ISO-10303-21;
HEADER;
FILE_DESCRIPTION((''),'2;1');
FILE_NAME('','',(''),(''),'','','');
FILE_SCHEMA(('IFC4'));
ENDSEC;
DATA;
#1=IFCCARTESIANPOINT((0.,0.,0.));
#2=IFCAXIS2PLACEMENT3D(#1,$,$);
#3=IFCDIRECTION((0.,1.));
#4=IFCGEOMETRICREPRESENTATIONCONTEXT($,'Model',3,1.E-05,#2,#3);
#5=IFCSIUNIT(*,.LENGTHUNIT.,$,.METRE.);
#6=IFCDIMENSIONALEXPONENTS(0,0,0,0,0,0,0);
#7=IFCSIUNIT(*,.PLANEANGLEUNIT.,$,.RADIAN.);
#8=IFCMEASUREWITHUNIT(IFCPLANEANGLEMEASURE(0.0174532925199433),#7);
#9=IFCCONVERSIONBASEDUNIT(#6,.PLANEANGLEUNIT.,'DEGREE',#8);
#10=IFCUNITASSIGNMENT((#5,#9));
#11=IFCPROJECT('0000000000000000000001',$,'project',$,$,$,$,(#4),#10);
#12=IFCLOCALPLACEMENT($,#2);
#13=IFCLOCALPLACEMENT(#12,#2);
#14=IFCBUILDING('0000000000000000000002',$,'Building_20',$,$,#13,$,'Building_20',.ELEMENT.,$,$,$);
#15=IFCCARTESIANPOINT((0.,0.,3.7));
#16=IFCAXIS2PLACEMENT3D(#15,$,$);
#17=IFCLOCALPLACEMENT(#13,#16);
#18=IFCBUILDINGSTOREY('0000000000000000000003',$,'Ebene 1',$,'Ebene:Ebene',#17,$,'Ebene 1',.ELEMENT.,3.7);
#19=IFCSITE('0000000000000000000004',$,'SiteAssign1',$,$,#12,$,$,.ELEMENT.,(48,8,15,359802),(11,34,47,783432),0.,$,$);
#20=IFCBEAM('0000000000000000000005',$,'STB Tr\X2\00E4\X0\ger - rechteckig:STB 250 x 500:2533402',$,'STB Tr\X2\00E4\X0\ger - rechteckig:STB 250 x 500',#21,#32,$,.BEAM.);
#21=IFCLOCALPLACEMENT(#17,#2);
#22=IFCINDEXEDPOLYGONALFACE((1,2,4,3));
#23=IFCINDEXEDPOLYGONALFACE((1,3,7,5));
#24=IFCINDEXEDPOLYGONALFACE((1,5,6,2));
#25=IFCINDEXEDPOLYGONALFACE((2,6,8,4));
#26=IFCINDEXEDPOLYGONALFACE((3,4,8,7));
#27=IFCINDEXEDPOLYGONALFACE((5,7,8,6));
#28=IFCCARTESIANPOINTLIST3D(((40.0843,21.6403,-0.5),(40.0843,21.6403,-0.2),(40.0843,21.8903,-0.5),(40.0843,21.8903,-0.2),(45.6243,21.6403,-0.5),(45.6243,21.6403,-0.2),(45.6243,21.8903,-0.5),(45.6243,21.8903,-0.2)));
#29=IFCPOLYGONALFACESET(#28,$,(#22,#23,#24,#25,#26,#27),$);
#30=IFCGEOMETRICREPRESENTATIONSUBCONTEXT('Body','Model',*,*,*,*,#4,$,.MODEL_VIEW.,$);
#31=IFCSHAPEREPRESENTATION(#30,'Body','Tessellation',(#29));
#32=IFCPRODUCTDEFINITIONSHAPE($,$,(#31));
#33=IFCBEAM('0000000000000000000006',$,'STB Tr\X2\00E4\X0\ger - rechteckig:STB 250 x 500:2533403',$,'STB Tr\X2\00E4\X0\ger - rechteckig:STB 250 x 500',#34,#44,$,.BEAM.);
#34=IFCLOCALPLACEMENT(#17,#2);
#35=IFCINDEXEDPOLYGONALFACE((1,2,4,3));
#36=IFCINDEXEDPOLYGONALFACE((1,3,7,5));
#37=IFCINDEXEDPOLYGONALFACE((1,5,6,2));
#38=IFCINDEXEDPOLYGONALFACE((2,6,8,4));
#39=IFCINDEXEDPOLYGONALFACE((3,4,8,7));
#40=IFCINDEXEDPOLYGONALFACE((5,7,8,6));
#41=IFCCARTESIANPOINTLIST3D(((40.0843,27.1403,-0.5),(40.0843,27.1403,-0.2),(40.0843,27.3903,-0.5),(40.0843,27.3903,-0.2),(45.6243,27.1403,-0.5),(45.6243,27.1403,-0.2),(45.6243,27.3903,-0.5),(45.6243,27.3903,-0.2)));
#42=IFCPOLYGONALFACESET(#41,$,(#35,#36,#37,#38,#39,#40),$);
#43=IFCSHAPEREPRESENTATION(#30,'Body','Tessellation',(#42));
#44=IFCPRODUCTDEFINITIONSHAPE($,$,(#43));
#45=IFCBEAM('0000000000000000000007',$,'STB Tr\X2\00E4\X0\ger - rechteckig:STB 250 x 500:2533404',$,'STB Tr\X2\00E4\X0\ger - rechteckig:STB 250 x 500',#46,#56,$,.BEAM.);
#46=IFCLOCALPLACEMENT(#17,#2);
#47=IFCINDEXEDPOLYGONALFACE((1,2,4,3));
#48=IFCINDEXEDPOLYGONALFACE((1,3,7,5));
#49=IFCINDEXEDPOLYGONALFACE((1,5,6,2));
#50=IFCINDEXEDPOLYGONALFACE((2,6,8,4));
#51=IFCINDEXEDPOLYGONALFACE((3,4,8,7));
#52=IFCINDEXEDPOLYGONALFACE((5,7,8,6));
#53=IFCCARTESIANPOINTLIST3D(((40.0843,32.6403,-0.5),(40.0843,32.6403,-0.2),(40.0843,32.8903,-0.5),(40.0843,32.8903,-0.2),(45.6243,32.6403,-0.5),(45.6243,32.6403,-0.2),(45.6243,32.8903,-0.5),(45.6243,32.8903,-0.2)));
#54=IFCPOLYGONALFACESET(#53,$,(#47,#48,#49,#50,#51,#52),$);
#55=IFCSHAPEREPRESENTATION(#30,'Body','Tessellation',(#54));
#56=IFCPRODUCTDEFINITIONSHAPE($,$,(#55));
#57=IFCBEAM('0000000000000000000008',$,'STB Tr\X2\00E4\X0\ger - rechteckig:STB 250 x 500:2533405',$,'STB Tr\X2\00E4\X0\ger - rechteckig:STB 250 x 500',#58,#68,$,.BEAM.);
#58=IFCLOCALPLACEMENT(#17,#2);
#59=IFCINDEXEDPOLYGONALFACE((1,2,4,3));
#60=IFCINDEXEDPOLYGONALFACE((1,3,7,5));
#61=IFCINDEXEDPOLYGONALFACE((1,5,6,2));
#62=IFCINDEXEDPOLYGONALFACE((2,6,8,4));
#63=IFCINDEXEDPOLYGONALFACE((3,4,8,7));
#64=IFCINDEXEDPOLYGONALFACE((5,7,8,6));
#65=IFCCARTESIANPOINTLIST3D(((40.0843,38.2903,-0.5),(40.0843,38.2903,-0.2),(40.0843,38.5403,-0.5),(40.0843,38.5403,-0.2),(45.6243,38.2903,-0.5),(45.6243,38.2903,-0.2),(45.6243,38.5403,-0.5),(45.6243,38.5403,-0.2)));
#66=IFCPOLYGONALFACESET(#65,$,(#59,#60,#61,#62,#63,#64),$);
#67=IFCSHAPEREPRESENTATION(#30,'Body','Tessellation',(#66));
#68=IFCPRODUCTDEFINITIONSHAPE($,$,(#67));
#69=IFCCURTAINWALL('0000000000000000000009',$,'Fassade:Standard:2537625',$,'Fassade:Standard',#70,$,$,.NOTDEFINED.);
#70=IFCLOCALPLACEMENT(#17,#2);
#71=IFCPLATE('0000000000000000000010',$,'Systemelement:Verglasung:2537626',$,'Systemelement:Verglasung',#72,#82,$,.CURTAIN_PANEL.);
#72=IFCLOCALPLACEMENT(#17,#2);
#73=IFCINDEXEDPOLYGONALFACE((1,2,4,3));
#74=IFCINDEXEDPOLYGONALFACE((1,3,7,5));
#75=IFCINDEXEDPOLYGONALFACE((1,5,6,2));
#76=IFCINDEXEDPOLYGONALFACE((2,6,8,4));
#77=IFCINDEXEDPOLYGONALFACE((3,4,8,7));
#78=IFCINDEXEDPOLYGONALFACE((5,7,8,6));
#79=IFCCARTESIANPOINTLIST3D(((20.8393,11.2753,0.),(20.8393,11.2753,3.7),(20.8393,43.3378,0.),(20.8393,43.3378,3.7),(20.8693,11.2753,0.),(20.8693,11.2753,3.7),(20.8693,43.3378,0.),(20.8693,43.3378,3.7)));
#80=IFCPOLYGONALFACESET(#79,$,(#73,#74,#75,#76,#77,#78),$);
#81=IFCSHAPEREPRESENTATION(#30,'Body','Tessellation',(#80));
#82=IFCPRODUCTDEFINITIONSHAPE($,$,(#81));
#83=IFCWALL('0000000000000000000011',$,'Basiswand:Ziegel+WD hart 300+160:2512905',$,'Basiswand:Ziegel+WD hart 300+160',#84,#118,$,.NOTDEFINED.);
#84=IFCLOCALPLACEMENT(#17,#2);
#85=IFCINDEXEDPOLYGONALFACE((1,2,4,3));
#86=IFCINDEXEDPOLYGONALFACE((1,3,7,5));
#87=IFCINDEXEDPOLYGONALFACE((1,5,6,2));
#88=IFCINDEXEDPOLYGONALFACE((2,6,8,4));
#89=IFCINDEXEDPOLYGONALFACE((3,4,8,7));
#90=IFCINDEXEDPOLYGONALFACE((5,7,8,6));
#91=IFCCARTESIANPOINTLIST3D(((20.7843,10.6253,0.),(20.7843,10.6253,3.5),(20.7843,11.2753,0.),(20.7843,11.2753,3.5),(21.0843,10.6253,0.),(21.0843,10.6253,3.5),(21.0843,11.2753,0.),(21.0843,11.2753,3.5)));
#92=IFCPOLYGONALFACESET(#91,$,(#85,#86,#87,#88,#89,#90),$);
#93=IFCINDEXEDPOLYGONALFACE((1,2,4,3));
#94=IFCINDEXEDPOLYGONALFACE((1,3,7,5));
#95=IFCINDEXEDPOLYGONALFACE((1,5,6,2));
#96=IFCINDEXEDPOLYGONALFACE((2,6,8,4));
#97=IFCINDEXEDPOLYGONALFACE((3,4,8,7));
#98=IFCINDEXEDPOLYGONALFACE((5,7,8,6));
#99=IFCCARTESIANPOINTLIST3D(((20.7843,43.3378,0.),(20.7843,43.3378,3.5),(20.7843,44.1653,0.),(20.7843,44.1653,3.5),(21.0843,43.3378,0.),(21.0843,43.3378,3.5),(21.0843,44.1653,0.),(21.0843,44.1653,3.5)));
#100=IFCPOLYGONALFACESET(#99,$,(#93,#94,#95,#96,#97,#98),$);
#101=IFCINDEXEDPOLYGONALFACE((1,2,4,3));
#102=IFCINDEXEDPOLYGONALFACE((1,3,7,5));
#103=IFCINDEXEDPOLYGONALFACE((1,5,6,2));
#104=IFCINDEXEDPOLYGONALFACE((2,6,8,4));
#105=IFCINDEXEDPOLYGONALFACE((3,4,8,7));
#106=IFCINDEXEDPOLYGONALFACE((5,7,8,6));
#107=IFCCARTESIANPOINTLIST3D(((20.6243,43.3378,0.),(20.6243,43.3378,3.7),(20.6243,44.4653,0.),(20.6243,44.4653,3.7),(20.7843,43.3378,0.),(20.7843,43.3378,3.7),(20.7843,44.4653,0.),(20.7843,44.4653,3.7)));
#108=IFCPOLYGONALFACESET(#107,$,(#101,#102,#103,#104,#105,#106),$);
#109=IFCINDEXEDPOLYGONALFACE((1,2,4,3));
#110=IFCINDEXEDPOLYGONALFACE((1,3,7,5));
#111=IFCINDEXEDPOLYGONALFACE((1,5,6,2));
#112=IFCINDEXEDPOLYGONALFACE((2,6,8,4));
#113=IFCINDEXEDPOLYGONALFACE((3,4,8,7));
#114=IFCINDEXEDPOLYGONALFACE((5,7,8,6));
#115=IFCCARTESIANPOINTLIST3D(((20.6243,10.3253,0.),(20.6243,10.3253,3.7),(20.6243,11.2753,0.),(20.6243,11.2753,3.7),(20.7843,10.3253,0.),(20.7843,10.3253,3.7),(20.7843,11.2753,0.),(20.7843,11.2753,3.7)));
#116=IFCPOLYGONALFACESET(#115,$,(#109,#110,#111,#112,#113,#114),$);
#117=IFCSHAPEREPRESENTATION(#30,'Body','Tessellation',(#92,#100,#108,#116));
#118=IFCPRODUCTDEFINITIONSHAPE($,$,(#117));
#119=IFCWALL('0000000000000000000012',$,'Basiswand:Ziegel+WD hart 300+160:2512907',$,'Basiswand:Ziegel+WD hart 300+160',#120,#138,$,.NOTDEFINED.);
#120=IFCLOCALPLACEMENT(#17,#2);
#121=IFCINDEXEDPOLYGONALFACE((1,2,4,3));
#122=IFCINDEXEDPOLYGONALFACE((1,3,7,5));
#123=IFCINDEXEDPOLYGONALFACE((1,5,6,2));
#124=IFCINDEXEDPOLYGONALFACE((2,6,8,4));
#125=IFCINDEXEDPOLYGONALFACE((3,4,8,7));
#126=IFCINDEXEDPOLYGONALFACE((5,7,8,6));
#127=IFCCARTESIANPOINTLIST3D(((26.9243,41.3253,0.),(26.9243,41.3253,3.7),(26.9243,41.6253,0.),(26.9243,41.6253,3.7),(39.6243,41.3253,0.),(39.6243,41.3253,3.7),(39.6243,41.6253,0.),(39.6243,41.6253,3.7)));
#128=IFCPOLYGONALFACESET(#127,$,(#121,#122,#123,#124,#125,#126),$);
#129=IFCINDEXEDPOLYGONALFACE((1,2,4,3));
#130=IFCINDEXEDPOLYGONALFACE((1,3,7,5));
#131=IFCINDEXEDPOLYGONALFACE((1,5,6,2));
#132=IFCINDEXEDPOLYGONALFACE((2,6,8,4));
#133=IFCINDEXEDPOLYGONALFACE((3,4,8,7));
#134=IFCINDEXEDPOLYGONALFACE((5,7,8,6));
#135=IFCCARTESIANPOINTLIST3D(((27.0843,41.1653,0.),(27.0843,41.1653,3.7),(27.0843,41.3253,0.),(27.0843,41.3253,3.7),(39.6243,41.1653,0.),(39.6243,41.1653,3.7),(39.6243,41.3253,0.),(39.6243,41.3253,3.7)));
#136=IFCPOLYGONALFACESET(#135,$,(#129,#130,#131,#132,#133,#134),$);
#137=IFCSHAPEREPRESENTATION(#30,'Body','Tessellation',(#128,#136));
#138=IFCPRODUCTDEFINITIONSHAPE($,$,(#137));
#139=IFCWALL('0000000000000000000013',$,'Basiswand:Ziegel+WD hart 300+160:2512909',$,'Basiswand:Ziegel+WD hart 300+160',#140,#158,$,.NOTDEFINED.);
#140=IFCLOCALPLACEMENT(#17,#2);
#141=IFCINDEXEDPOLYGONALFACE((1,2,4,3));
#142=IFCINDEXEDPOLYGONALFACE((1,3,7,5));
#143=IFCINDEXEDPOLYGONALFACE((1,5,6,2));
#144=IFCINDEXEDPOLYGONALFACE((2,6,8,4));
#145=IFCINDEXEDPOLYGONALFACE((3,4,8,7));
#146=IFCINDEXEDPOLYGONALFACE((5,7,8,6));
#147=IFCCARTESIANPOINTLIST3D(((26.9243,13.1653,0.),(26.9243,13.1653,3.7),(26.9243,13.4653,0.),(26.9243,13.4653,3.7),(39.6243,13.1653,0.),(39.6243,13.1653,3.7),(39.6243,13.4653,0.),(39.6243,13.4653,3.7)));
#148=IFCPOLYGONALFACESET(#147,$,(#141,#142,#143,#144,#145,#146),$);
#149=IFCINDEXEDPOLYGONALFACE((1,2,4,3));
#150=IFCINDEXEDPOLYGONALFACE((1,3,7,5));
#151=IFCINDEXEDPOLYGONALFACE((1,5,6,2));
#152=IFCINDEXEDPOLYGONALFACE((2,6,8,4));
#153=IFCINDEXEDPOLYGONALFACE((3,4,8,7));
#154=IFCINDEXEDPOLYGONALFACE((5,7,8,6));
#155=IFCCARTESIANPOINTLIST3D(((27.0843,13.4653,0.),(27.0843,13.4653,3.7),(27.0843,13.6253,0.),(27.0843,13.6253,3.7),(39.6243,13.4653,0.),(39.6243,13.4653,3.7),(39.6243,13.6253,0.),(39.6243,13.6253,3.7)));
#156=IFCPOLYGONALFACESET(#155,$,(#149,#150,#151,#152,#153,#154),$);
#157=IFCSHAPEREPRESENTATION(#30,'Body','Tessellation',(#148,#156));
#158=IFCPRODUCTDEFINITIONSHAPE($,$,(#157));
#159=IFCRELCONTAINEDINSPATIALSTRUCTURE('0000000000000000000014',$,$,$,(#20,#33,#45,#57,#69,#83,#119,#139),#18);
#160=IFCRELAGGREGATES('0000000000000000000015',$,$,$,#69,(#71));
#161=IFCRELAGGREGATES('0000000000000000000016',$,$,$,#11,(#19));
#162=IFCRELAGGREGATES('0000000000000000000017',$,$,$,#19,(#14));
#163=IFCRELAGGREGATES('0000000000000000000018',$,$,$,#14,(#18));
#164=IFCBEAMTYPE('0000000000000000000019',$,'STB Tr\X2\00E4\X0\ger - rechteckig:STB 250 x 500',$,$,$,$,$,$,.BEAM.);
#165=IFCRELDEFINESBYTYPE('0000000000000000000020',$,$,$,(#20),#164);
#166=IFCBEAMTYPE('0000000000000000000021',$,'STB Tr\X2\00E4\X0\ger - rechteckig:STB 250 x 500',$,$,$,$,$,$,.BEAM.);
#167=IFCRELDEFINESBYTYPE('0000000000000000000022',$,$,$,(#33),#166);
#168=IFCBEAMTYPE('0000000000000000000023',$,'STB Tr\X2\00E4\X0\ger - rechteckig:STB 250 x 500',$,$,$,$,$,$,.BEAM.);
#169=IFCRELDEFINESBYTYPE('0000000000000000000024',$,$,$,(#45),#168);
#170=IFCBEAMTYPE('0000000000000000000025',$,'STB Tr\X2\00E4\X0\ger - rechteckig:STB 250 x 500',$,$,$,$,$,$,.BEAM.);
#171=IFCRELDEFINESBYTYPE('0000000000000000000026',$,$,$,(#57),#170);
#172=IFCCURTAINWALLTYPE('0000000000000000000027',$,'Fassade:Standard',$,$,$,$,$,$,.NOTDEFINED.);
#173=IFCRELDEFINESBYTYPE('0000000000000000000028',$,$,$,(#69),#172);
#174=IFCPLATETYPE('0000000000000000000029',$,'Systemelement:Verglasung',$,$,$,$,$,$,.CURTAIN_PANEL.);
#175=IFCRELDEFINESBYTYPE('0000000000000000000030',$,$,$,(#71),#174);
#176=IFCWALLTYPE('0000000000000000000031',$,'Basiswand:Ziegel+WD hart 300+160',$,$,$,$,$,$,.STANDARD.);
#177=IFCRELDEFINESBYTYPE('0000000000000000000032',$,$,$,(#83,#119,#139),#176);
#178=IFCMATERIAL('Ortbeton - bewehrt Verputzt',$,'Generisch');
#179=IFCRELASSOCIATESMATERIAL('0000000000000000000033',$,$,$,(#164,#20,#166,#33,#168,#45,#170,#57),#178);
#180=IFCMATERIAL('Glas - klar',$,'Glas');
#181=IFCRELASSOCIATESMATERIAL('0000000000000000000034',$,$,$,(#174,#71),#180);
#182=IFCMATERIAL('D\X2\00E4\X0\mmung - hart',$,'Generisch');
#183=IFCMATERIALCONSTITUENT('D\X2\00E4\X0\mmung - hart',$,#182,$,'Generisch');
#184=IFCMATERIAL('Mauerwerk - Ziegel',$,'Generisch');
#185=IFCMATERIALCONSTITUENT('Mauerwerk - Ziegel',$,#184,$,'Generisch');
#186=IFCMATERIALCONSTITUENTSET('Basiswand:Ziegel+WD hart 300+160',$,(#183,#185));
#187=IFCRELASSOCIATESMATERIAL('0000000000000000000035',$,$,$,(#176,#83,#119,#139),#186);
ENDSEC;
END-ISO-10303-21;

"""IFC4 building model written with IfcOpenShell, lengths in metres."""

from ifc_helpers import new_model, entity, si_unit, converted_unit, direction, frame, origin, place, context, subcontext, project, spatial, indexed_curve, outline, extrude, source, transform, mapped, material, constituent, constituent_set, type_object, type_shapes, element, aggregate, save


model = new_model("IFC4")

# Units and contexts
model_context = context("Model", 3, precision=1e-05, world=origin(), true_north=direction((0.0, 1.0)))
body_context = subcontext(model_context, "Body", "Model", "MODEL_VIEW")
ifc_project = project(units=[si_unit("LENGTHUNIT", "METRE"), converted_unit("PLANEANGLEUNIT", "DEGREE", entity("IfcPlaneAngleMeasure", 0.0174532925199433), si_unit("PLANEANGLEUNIT", "RADIAN"), dimensions=[0, 0, 0, 0, 0, 0, 0])], contexts=[model_context])

# Site, building, storey
site_placement = place(None, origin())
site = spatial("IfcSite", under=ifc_project, at=site_placement, Name="SiteAssign1", CompositionType="ELEMENT", RefLatitude=(48, 8, 15, 359802), RefLongitude=(11, 34, 47, 783432), RefElevation=0.0)
building_placement = place(site_placement, origin())
building = spatial("IfcBuilding", under=site, at=building_placement, Name="Building_20", LongName="Building_20", CompositionType="ELEMENT")
storey_placement = place(building_placement, frame((0.0, 0.0, 3.7)))
storey = spatial("IfcBuildingStorey", under=building, at=storey_placement, Name="Ebene 1", ObjectType="Ebene:Ebene", LongName="Ebene 1", CompositionType="ELEMENT", Elevation=3.7)

# Beams
ifc_material_1 = material(Name="Ortbeton - bewehrt Verputzt", Category="Generisch")
beam_type_1 = type_object("IfcBeamType", Name="STB Träger - rechteckig:STB 250 x 500", PredefinedType="BEAM", material=ifc_material_1)
shared_shape_1 = source(origin(), body_context, "Body", "SweptSolid", [
    extrude(outline(indexed_curve([(-0.15, -0.125), (0.15, -0.125), (0.15, 0.125), (-0.15, 0.125), (-0.15, -0.125)], self_intersect=False)), frame((40.0843, 21.7653, 3.35), z_axis=(1.0, 0.0, 0.0), x_axis=(0.0, 0.0, -1.0)), (0.0, 0.0, 1.0), 5.54),
])
type_shapes(beam_type_1, [shared_shape_1])
beam_1_placement = place(storey_placement, frame((0.0, 0.0, -3.7)))
element("IfcBeam", 1, at=beam_1_placement, inside=storey, type_object=beam_type_1, material=ifc_material_1, Name="STB Träger - rechteckig:STB 250 x 500:2533402", ObjectType="STB Träger - rechteckig:STB 250 x 500", PredefinedType="BEAM", context=body_context, shape_type="MappedRepresentation", body=[
    mapped(shared_shape_1, transform((0.0, 0.0, 0.0), scale=1.0)),
])
beam_type_2 = type_object("IfcBeamType", Name="STB Träger - rechteckig:STB 250 x 500", PredefinedType="BEAM", material=ifc_material_1)
shared_shape_2 = source(origin(), body_context, "Body", "SweptSolid", [
    extrude(outline(indexed_curve([(-0.15, -0.125), (0.15, -0.125), (0.15, 0.125), (-0.15, 0.125), (-0.15, -0.125)], self_intersect=False)), frame((40.0843, 27.2653, 3.35), z_axis=(1.0, 0.0, 0.0), x_axis=(0.0, 0.0, -1.0)), (0.0, 0.0, 1.0), 5.54),
])
type_shapes(beam_type_2, [shared_shape_2])
beam_2_placement = place(storey_placement, frame((0.0, 0.0, -3.7)))
element("IfcBeam", 2, at=beam_2_placement, inside=storey, type_object=beam_type_2, material=ifc_material_1, Name="STB Träger - rechteckig:STB 250 x 500:2533403", ObjectType="STB Träger - rechteckig:STB 250 x 500", PredefinedType="BEAM", context=body_context, shape_type="MappedRepresentation", body=[
    mapped(shared_shape_2, transform((0.0, 0.0, 0.0), scale=1.0)),
])
beam_type_3 = type_object("IfcBeamType", Name="STB Träger - rechteckig:STB 250 x 500", PredefinedType="BEAM", material=ifc_material_1)
shared_shape_3 = source(origin(), body_context, "Body", "SweptSolid", [
    extrude(outline(indexed_curve([(-0.15, -0.125), (0.15, -0.125), (0.15, 0.125), (-0.15, 0.125), (-0.15, -0.125)], self_intersect=False)), frame((40.0843, 32.7653, 3.35), z_axis=(1.0, 0.0, 0.0), x_axis=(0.0, 0.0, -1.0)), (0.0, 0.0, 1.0), 5.54),
])
type_shapes(beam_type_3, [shared_shape_3])
beam_3_placement = place(storey_placement, frame((0.0, 0.0, -3.7)))
element("IfcBeam", 3, at=beam_3_placement, inside=storey, type_object=beam_type_3, material=ifc_material_1, Name="STB Träger - rechteckig:STB 250 x 500:2533404", ObjectType="STB Träger - rechteckig:STB 250 x 500", PredefinedType="BEAM", context=body_context, shape_type="MappedRepresentation", body=[
    mapped(shared_shape_3, transform((0.0, 0.0, 0.0), scale=1.0)),
])
beam_type_4 = type_object("IfcBeamType", Name="STB Träger - rechteckig:STB 250 x 500", PredefinedType="BEAM", material=ifc_material_1)
shared_shape_4 = source(origin(), body_context, "Body", "SweptSolid", [
    extrude(outline(indexed_curve([(-0.15, -0.125), (0.15, -0.125), (0.15, 0.125), (-0.15, 0.125), (-0.15, -0.125)], self_intersect=False)), frame((40.0843, 38.4153, 3.35), z_axis=(1.0, 0.0, 0.0), x_axis=(0.0, 0.0, -1.0)), (0.0, 0.0, 1.0), 5.54),
])
type_shapes(beam_type_4, [shared_shape_4])
beam_4_placement = place(storey_placement, frame((0.0, 0.0, -3.7)))
element("IfcBeam", 4, at=beam_4_placement, inside=storey, type_object=beam_type_4, material=ifc_material_1, Name="STB Träger - rechteckig:STB 250 x 500:2533405", ObjectType="STB Träger - rechteckig:STB 250 x 500", PredefinedType="BEAM", context=body_context, shape_type="MappedRepresentation", body=[
    mapped(shared_shape_4, transform((0.0, 0.0, 0.0), scale=1.0)),
])

# Curtain wall, plate
curtain_wall_type = type_object("IfcCurtainWallType", Name="Fassade:Standard", PredefinedType="NOTDEFINED")
curtain_wall_placement = place(storey_placement, frame((0.0, 0.0, -3.7)))
curtain_wall = element("IfcCurtainWall", 5, at=curtain_wall_placement, inside=storey, type_object=curtain_wall_type, Name="Fassade:Standard:2537625", ObjectType="Fassade:Standard", PredefinedType="NOTDEFINED")
ifc_material_2 = material(Name="Glas - klar", Category="Glas")
plate_type = type_object("IfcPlateType", Name="Systemelement:Verglasung", PredefinedType="CURTAIN_PANEL", material=ifc_material_2)
shared_shape_5 = source(origin(), body_context, "Body", "SweptSolid", [
    extrude(outline(indexed_curve([(-0.015, -16.0312), (0.015, -16.0312), (0.015, 16.0312), (-0.015, 16.0312), (-0.015, -16.0312)], self_intersect=False)), frame((0.0, 0.0, 0.0), z_axis=(0.0, 0.0, 1.0), x_axis=(0.0, 1.0, 0.0)), (0.0, 0.0, 1.0), 3.7),
])
type_shapes(plate_type, [shared_shape_5])
plate_placement = place(curtain_wall_placement, frame((20.8543, 27.3066, 3.7), z_axis=(0.0, 0.0, 1.0), x_axis=(0.0, -1.0, 0.0)))
plate = element("IfcPlate", 6, at=plate_placement, type_object=plate_type, material=ifc_material_2, Name="Systemelement:Verglasung:2537626", ObjectType="Systemelement:Verglasung", PredefinedType="CURTAIN_PANEL", context=body_context, shape_type="MappedRepresentation", body=[
    mapped(shared_shape_5, transform((0.0, 0.0, 0.0), scale=1.0)),
])
aggregate(curtain_wall, [plate])

# Wall, openings
ifc_material_3 = material(Name="Dämmung - hart", Category="Generisch")
ifc_constituent_1 = constituent(ifc_material_3, Name="Dämmung - hart", Category="Generisch")
ifc_material_4 = material(Name="Mauerwerk - Ziegel", Category="Generisch")
ifc_constituent_2 = constituent(ifc_material_4, Name="Mauerwerk - Ziegel", Category="Generisch")
ifc_constituent_set = constituent_set(constituents=[ifc_constituent_1, ifc_constituent_2], Name="Basiswand:Ziegel+WD hart 300+160")
wall_type_1 = type_object("IfcWallType", Name="Basiswand:Ziegel+WD hart 300+160", PredefinedType="STANDARD", material=ifc_constituent_set)
wall_1_placement = place(storey_placement, frame((20.8543, 10.6253, 0.0), z_axis=(0.0, 0.0, 1.0), x_axis=(0.0, 1.0, 0.0)))
wall_1 = element("IfcWall", 7, at=wall_1_placement, inside=storey, type_object=wall_type_1, material=ifc_constituent_set, Name="Basiswand:Ziegel+WD hart 300+160:2512905", ObjectType="Basiswand:Ziegel+WD hart 300+160", PredefinedType="NOTDEFINED", context=body_context, shape_type="SweptSolid", body=[
    extrude(outline(indexed_curve([(-0.325, -1.75), (0.325, -1.75), (0.325, 1.75), (-0.325, 1.75), (-0.325, -1.75)], self_intersect=False)), frame((0.325, 0.07, 1.75), z_axis=(0.0, -1.0, 0.0), x_axis=(1.0, 0.0, 0.0)), (0.0, 0.0, 1.0), 0.3),
    extrude(outline(indexed_curve([(-0.4138, -1.75), (0.4138, -1.75), (0.4138, 1.75), (-0.4138, 1.75), (-0.4138, -1.75)], self_intersect=False)), frame((33.1262, 0.07, 1.75), z_axis=(0.0, -1.0, 0.0), x_axis=(-1.0, 0.0, 0.0)), (0.0, 0.0, 1.0), 0.3),
    extrude(outline(indexed_curve([(-0.08, -0.5637), (0.08, -0.5637), (0.08, 0.5638), (-0.08, 0.5638), (-0.08, -0.5637)], self_intersect=False)), frame((33.2762, 0.15, 0.0), z_axis=(0.0, 0.0, 1.0), x_axis=(0.0, -1.0, 0.0)), (0.0, 0.0, 1.0), 3.7),
    extrude(outline(indexed_curve([(-0.08, -0.475), (0.08, -0.475), (0.08, 0.475), (-0.08, 0.475), (-0.08, -0.475)], self_intersect=False)), frame((0.175, 0.15, 0.0), z_axis=(0.0, 0.0, 1.0), x_axis=(0.0, -1.0, 0.0)), (0.0, 0.0, 1.0), 3.7),
])
opening_1_placement = place(wall_1_placement, origin())
element("IfcOpeningElement", 8, at=opening_1_placement, cuts=wall_1, PredefinedType="OPENING", context=body_context, shape_type="SweptSolid", body=[
    extrude(outline(indexed_curve([(-16.0312, -1.85), (16.0312, -1.85), (16.0312, 1.85), (-16.0312, 1.85), (-16.0312, -1.85)], self_intersect=False)), frame((16.6812, -0.3824, 1.85), z_axis=(0.0, 1.0, 0.0), x_axis=(-1.0, 0.0, 0.0)), (0.0, 0.0, 1.0), 0.7648),
])
opening_2_placement = place(wall_1_placement, origin())
element("IfcOpeningElement", 9, at=opening_2_placement, cuts=wall_1, PredefinedType="OPENING", context=body_context, shape_type="SweptSolid", body=[
    extrude(outline(indexed_curve([(-1.65, -16.0312), (1.65, -16.0312), (1.65, 16.0312), (-1.65, 16.0312), (-1.65, -16.0312)], self_intersect=False)), frame((16.6812, 0.23, 1.85), z_axis=(0.0, -1.0, 0.0), x_axis=(0.0, 0.0, -1.0)), (0.0, 0.0, 1.0), 0.46),
])

# Walls
wall_2_placement = place(storey_placement, frame((39.6243, 41.3953, 0.0), z_axis=(0.0, 0.0, 1.0), x_axis=(-1.0, 0.0, 0.0)))
element("IfcWall", 10, at=wall_2_placement, inside=storey, type_object=wall_type_1, material=ifc_constituent_set, Name="Basiswand:Ziegel+WD hart 300+160:2512907", ObjectType="Basiswand:Ziegel+WD hart 300+160", PredefinedType="NOTDEFINED", context=body_context, shape_type="SweptSolid", body=[
    extrude(outline(indexed_curve([(-0.15, -6.35), (0.15, -6.35), (0.15, 6.35), (-0.15, 6.35), (-0.15, -6.35)], self_intersect=False)), frame((6.35, -0.08, 0.0), z_axis=(0.0, 0.0, 1.0), x_axis=(0.0, 1.0, 0.0)), (0.0, 0.0, 1.0), 3.7),
    extrude(outline(indexed_curve([(-0.08, -6.27), (0.08, -6.27), (0.08, 6.27), (-0.08, 6.27), (-0.08, -6.27)], self_intersect=False)), frame((6.27, 0.15, 0.0), z_axis=(0.0, 0.0, 1.0), x_axis=(0.0, -1.0, 0.0)), (0.0, 0.0, 1.0), 3.7),
])
wall_3_placement = place(storey_placement, frame((27.0843, 13.3953, 0.0)))
element("IfcWall", 11, at=wall_3_placement, inside=storey, type_object=wall_type_1, material=ifc_constituent_set, Name="Basiswand:Ziegel+WD hart 300+160:2512909", ObjectType="Basiswand:Ziegel+WD hart 300+160", PredefinedType="NOTDEFINED", context=body_context, shape_type="SweptSolid", body=[
    extrude(outline(indexed_curve([(-0.15, -6.35), (0.15, -6.35), (0.15, 6.35), (-0.15, 6.35), (-0.15, -6.35)], self_intersect=False)), frame((6.19, -0.08, 0.0), z_axis=(0.0, 0.0, 1.0), x_axis=(0.0, 1.0, 0.0)), (0.0, 0.0, 1.0), 3.7),
    extrude(outline(indexed_curve([(-0.08, -6.27), (0.08, -6.27), (0.08, 6.27), (-0.08, 6.27), (-0.08, -6.27)], self_intersect=False)), frame((6.27, 0.15, 0.0), z_axis=(0.0, 0.0, 1.0), x_axis=(0.0, -1.0, 0.0)), (0.0, 0.0, 1.0), 3.7),
])

save(model, "model.ifc")
